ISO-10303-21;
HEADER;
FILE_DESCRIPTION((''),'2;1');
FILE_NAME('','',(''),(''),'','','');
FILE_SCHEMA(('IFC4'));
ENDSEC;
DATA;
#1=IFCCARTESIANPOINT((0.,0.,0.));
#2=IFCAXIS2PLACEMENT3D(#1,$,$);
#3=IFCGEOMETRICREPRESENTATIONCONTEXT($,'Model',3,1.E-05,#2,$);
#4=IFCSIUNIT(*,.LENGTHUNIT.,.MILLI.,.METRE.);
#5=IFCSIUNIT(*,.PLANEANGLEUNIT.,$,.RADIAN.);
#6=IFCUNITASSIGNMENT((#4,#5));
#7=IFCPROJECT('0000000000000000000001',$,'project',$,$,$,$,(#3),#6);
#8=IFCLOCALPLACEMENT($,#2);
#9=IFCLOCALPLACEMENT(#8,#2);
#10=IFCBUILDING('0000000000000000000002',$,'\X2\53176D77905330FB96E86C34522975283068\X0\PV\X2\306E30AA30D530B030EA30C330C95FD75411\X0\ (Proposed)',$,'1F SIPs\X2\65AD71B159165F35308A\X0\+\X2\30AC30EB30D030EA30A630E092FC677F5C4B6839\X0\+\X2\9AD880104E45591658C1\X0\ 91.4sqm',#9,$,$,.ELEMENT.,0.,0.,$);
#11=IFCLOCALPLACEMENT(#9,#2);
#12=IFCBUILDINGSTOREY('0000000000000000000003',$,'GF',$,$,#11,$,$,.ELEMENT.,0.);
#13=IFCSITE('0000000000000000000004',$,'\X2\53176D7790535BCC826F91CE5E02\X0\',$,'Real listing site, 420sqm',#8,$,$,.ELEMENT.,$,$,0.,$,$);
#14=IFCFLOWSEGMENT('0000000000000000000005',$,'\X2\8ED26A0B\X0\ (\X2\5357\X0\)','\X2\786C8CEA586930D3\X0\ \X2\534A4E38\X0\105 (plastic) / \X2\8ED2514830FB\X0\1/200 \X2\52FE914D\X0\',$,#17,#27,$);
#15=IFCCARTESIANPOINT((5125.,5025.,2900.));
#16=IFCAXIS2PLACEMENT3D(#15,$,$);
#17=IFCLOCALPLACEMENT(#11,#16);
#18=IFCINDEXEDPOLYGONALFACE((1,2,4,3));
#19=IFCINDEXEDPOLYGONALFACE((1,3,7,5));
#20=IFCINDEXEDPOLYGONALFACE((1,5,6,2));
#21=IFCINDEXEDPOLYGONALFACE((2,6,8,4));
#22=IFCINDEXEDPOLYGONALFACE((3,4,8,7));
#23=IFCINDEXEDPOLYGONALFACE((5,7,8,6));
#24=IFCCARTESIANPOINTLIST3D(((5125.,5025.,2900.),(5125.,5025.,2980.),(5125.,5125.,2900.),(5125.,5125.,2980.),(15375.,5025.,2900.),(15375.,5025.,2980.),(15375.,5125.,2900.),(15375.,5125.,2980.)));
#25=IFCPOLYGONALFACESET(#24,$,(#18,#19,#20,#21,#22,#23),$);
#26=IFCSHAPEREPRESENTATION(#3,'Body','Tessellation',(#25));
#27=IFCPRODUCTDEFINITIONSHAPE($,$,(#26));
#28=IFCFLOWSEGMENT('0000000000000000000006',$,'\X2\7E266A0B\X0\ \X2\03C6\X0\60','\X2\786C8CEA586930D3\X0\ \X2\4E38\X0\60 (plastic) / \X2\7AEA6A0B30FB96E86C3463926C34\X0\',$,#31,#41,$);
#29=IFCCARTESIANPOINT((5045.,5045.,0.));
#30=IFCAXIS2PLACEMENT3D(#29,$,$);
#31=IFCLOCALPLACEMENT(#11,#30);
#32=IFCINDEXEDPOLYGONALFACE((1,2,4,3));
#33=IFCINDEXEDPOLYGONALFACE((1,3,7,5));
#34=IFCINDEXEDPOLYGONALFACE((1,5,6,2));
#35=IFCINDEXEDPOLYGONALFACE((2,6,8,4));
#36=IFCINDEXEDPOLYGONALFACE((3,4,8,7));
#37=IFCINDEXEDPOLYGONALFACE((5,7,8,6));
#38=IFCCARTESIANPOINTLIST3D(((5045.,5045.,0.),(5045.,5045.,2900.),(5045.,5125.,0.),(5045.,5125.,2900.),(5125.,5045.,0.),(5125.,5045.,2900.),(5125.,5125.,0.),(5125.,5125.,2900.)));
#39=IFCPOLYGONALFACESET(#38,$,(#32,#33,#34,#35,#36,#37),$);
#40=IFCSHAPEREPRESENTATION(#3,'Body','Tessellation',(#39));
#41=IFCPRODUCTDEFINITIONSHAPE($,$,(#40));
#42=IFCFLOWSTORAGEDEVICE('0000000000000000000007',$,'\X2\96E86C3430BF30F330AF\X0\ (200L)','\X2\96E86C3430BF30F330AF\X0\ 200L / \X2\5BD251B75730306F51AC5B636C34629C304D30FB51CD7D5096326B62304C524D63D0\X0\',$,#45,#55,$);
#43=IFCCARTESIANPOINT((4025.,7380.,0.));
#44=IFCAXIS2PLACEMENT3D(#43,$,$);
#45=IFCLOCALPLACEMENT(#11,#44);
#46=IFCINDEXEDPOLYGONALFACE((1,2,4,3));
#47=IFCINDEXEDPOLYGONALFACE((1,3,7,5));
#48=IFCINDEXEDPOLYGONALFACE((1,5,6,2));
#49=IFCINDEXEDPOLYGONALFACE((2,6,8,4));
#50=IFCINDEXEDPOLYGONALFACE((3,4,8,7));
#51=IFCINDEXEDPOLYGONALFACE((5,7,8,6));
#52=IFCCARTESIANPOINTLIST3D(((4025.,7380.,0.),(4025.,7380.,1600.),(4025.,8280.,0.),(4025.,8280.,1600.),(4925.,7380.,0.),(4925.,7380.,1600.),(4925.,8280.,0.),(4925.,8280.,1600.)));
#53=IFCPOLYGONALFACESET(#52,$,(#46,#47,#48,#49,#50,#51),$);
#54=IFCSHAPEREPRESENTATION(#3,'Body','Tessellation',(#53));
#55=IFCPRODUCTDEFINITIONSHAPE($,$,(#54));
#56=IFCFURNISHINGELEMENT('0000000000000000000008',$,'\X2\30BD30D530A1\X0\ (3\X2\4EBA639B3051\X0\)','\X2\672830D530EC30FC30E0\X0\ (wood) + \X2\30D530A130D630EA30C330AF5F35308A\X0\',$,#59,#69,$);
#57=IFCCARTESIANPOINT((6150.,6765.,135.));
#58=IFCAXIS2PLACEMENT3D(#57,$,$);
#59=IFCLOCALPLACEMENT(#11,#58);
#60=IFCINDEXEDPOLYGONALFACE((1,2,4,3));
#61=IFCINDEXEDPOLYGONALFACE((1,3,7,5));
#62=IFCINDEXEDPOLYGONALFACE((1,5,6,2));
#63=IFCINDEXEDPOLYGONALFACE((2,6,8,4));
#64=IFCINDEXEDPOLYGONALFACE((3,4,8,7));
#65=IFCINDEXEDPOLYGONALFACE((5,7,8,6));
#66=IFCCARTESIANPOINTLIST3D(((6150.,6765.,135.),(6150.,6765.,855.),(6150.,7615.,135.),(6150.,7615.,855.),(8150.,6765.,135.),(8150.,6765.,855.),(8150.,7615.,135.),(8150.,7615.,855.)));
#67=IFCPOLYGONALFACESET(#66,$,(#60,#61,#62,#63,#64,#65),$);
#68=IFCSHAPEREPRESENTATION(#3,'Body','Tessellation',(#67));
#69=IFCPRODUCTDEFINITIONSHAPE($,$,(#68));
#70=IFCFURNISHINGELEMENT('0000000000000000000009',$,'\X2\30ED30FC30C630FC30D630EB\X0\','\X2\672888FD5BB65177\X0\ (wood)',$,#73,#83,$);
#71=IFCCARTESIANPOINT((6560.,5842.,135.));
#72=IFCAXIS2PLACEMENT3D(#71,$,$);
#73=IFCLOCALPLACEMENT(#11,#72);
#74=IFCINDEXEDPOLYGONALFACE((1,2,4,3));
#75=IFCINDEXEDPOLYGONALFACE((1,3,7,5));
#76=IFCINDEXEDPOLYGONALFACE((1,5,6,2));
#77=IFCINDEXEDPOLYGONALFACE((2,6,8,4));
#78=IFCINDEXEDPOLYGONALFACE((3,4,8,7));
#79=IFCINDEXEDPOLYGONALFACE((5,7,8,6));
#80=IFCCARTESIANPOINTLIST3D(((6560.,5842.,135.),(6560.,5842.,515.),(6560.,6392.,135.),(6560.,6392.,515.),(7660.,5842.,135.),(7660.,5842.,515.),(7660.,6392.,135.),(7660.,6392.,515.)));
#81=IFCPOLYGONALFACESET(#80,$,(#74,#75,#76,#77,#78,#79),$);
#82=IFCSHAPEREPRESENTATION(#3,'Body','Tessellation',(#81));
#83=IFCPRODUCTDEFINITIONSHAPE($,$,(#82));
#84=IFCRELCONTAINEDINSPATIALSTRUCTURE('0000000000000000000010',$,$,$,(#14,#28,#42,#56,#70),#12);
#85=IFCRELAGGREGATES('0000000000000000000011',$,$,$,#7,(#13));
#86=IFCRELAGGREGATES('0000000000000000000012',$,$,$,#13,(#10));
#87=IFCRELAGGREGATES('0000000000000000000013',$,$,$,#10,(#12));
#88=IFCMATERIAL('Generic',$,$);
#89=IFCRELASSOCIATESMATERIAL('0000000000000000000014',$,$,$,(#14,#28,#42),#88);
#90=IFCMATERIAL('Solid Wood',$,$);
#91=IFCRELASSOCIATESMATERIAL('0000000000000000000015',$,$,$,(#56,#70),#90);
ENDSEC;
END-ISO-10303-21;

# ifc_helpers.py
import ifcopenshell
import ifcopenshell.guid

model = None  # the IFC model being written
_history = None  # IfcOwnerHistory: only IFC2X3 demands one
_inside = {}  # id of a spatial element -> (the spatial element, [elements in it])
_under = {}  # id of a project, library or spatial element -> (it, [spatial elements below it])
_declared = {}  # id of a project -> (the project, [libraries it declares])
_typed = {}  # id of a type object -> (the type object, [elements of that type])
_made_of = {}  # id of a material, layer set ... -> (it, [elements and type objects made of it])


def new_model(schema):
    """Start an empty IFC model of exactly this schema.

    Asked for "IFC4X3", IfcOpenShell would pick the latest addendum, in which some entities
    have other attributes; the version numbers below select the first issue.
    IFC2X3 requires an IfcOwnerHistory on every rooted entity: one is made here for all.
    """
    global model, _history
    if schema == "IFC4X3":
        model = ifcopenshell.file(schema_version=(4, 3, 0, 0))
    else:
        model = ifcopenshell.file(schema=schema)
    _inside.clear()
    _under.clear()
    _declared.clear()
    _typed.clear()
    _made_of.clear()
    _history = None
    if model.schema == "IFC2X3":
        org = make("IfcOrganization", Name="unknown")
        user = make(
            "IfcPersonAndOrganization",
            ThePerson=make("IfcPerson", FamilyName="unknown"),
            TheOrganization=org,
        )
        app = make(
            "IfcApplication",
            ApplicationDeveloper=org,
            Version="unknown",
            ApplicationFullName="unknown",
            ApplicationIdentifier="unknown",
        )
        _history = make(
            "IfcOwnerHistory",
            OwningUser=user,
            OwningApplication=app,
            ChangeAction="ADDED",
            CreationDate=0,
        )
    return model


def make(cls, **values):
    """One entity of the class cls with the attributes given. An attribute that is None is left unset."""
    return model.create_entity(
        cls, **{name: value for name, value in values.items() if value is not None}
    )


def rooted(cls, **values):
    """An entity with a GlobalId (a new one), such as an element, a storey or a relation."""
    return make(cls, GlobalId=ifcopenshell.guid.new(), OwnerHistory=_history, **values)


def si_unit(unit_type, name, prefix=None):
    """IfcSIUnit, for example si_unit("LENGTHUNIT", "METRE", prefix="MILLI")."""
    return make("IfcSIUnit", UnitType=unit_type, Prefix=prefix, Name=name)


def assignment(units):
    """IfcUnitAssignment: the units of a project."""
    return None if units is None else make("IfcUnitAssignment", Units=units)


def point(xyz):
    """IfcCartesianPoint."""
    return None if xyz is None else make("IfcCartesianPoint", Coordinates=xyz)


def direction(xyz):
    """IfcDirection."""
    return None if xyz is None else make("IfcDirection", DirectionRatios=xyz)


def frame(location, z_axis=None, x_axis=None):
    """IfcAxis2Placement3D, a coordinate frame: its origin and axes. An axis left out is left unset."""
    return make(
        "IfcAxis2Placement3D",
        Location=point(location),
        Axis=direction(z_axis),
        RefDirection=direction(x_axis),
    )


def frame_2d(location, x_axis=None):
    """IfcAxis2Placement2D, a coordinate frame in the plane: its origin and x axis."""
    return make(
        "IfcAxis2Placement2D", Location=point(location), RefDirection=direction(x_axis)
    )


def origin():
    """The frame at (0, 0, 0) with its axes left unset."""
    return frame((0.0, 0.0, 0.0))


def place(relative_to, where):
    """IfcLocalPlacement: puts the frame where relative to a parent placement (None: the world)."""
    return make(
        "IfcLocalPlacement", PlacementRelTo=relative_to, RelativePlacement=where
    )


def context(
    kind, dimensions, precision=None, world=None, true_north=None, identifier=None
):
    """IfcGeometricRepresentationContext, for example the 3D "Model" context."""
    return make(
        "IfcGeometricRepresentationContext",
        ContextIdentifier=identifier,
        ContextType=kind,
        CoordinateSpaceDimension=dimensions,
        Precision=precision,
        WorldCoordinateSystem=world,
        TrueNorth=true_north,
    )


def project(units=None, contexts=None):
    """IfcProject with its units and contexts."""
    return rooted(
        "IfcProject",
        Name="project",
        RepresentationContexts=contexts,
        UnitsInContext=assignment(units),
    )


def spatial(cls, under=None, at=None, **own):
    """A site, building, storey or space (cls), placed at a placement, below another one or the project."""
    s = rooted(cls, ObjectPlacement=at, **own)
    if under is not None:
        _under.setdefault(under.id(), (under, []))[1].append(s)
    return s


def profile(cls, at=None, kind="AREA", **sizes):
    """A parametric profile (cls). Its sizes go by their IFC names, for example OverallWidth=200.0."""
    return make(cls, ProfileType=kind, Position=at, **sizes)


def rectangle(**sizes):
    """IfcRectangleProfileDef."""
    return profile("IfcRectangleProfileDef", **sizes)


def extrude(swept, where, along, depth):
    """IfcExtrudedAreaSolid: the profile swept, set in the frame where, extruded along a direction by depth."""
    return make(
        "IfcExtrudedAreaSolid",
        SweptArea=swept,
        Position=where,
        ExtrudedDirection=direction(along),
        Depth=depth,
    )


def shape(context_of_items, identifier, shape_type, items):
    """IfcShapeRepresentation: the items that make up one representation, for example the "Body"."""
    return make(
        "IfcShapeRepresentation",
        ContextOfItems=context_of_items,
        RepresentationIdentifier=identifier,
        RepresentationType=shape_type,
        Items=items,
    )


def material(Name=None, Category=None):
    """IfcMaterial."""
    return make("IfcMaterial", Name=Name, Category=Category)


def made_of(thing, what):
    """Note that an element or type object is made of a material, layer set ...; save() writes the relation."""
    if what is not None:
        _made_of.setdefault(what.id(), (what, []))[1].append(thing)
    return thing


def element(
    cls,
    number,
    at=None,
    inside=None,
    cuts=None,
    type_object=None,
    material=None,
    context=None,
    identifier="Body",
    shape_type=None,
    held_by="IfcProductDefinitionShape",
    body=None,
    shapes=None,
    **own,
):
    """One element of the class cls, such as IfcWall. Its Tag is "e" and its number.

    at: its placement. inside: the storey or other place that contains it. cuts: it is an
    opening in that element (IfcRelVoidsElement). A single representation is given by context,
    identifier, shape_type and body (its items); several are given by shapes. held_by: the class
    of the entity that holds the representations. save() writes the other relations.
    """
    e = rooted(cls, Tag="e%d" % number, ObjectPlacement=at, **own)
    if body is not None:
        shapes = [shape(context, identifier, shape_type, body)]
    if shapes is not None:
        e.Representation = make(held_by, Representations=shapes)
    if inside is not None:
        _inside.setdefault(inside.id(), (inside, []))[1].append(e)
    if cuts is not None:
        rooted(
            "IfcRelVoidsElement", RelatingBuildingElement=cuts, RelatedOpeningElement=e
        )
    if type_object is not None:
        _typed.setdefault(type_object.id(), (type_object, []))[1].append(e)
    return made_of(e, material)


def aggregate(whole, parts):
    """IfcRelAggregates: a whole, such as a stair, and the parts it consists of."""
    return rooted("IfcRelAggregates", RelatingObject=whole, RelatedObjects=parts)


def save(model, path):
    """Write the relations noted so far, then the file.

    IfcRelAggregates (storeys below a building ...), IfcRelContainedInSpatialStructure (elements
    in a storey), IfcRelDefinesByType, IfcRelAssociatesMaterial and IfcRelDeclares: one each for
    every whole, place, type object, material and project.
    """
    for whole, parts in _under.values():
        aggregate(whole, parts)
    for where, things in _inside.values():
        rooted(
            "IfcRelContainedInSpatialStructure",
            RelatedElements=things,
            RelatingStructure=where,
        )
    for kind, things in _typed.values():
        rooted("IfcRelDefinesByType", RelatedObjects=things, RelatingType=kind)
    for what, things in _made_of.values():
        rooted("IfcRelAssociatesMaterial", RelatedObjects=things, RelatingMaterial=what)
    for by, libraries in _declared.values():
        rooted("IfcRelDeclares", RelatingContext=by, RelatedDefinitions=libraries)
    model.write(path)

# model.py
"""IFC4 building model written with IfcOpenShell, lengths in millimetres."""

from ifc_helpers import new_model, si_unit, frame, frame_2d, origin, place, context, project, spatial, rectangle, extrude, material, element, save


model = new_model("IFC4")

# Units and contexts
model_context = context("Model", 3, precision=1e-05, world=origin())
ifc_project = project(units=[si_unit("LENGTHUNIT", "METRE", prefix="MILLI"), si_unit("PLANEANGLEUNIT", "RADIAN")], contexts=[model_context])

# Site, building, storey
site_placement = place(None, origin())
site = spatial("IfcSite", under=ifc_project, at=site_placement, Name="北海道富良野市", ObjectType="Real listing site, 420sqm", CompositionType="ELEMENT", RefElevation=0.0)
building_placement = place(site_placement, origin())
building = spatial("IfcBuilding", under=site, at=building_placement, Name="北海道・雨水利用とPVのオフグリッド志向 (Proposed)", ObjectType="1F SIPs断熱外張り+ガルバリウム鋼板屋根+高耐久外壁 91.4sqm", CompositionType="ELEMENT", ElevationOfRefHeight=0.0, ElevationOfTerrain=0.0)
storey_placement = place(building_placement, origin())
storey = spatial("IfcBuildingStorey", under=building, at=storey_placement, Name="GF", CompositionType="ELEMENT", Elevation=0.0)

# Shared definitions
ifc_material_1 = material(Name="Solid Wood")

# Shared definitions
ifc_material_2 = material(Name="Generic")

# Flow segments
flow_segment_1_placement = place(storey_placement, frame((5125.0, 5025.0, 2900.0)))
element("IfcFlowSegment", 1, at=flow_segment_1_placement, inside=storey, material=ifc_material_2, Name="軒樋 (南)", Description="硬質塩ビ 半丸105 (plastic) / 軒先・1/200 勾配", context=model_context, shape_type="SweptSolid", body=[
    extrude(rectangle(XDim=10250.0, YDim=100.0, at=frame_2d((5125.0, 50.0))), frame((5125.0, 5025.0, 2900.0)), (0.0, 0.0, 1.0), 80.0),
])
flow_segment_2_placement = place(storey_placement, frame((5045.0, 5045.0, 0.0)))
element("IfcFlowSegment", 2, at=flow_segment_2_placement, inside=storey, material=ifc_material_2, Name="縦樋 φ60", Description="硬質塩ビ 丸60 (plastic) / 竪樋・雨水排水", context=model_context, shape_type="SweptSolid", body=[
    extrude(rectangle(XDim=80.0, YDim=80.0, at=frame_2d((40.0, 40.0))), frame((5045.0, 5045.0, 0.0)), (0.0, 0.0, 1.0), 2900.0),
])

# Flow storage device
flow_storage_device_placement = place(storey_placement, frame((4025.0, 7380.0, 0.0)))
element("IfcFlowStorageDevice", 3, at=flow_storage_device_placement, inside=storey, material=ifc_material_2, Name="雨水タンク (200L)", Description="雨水タンク 200L / 寒冷地は冬季水抜き・凍結防止が前提", context=model_context, shape_type="SweptSolid", body=[
    extrude(rectangle(XDim=900.0, YDim=900.0, at=frame_2d((450.0, 450.0))), frame((4025.0, 7380.0, 0.0)), (0.0, 0.0, 1.0), 1600.0),
])

# Furnishing elements
furnishing_1_placement = place(storey_placement, frame((6150.0, 6765.0, 135.0)))
element("IfcFurnishingElement", 4, at=furnishing_1_placement, inside=storey, material=ifc_material_1, Name="ソファ (3人掛け)", Description="木フレーム (wood) + ファブリック張り", context=model_context, shape_type="SweptSolid", body=[
    extrude(rectangle(XDim=2000.0, YDim=850.0, at=frame_2d((1000.0, 425.0))), frame((6150.0, 6765.0, 135.0)), (0.0, 0.0, 1.0), 720.0),
])
furnishing_2_placement = place(storey_placement, frame((6560.0, 5842.0, 135.0)))
element("IfcFurnishingElement", 5, at=furnishing_2_placement, inside=storey, material=ifc_material_1, Name="ローテーブル", Description="木製家具 (wood)", context=model_context, shape_type="SweptSolid", body=[
    extrude(rectangle(XDim=1100.0, YDim=550.0, at=frame_2d((550.0, 275.0))), frame((6560.0, 5842.0, 135.0)), (0.0, 0.0, 1.0), 380.0),
])

save(model, "model.ifc")
